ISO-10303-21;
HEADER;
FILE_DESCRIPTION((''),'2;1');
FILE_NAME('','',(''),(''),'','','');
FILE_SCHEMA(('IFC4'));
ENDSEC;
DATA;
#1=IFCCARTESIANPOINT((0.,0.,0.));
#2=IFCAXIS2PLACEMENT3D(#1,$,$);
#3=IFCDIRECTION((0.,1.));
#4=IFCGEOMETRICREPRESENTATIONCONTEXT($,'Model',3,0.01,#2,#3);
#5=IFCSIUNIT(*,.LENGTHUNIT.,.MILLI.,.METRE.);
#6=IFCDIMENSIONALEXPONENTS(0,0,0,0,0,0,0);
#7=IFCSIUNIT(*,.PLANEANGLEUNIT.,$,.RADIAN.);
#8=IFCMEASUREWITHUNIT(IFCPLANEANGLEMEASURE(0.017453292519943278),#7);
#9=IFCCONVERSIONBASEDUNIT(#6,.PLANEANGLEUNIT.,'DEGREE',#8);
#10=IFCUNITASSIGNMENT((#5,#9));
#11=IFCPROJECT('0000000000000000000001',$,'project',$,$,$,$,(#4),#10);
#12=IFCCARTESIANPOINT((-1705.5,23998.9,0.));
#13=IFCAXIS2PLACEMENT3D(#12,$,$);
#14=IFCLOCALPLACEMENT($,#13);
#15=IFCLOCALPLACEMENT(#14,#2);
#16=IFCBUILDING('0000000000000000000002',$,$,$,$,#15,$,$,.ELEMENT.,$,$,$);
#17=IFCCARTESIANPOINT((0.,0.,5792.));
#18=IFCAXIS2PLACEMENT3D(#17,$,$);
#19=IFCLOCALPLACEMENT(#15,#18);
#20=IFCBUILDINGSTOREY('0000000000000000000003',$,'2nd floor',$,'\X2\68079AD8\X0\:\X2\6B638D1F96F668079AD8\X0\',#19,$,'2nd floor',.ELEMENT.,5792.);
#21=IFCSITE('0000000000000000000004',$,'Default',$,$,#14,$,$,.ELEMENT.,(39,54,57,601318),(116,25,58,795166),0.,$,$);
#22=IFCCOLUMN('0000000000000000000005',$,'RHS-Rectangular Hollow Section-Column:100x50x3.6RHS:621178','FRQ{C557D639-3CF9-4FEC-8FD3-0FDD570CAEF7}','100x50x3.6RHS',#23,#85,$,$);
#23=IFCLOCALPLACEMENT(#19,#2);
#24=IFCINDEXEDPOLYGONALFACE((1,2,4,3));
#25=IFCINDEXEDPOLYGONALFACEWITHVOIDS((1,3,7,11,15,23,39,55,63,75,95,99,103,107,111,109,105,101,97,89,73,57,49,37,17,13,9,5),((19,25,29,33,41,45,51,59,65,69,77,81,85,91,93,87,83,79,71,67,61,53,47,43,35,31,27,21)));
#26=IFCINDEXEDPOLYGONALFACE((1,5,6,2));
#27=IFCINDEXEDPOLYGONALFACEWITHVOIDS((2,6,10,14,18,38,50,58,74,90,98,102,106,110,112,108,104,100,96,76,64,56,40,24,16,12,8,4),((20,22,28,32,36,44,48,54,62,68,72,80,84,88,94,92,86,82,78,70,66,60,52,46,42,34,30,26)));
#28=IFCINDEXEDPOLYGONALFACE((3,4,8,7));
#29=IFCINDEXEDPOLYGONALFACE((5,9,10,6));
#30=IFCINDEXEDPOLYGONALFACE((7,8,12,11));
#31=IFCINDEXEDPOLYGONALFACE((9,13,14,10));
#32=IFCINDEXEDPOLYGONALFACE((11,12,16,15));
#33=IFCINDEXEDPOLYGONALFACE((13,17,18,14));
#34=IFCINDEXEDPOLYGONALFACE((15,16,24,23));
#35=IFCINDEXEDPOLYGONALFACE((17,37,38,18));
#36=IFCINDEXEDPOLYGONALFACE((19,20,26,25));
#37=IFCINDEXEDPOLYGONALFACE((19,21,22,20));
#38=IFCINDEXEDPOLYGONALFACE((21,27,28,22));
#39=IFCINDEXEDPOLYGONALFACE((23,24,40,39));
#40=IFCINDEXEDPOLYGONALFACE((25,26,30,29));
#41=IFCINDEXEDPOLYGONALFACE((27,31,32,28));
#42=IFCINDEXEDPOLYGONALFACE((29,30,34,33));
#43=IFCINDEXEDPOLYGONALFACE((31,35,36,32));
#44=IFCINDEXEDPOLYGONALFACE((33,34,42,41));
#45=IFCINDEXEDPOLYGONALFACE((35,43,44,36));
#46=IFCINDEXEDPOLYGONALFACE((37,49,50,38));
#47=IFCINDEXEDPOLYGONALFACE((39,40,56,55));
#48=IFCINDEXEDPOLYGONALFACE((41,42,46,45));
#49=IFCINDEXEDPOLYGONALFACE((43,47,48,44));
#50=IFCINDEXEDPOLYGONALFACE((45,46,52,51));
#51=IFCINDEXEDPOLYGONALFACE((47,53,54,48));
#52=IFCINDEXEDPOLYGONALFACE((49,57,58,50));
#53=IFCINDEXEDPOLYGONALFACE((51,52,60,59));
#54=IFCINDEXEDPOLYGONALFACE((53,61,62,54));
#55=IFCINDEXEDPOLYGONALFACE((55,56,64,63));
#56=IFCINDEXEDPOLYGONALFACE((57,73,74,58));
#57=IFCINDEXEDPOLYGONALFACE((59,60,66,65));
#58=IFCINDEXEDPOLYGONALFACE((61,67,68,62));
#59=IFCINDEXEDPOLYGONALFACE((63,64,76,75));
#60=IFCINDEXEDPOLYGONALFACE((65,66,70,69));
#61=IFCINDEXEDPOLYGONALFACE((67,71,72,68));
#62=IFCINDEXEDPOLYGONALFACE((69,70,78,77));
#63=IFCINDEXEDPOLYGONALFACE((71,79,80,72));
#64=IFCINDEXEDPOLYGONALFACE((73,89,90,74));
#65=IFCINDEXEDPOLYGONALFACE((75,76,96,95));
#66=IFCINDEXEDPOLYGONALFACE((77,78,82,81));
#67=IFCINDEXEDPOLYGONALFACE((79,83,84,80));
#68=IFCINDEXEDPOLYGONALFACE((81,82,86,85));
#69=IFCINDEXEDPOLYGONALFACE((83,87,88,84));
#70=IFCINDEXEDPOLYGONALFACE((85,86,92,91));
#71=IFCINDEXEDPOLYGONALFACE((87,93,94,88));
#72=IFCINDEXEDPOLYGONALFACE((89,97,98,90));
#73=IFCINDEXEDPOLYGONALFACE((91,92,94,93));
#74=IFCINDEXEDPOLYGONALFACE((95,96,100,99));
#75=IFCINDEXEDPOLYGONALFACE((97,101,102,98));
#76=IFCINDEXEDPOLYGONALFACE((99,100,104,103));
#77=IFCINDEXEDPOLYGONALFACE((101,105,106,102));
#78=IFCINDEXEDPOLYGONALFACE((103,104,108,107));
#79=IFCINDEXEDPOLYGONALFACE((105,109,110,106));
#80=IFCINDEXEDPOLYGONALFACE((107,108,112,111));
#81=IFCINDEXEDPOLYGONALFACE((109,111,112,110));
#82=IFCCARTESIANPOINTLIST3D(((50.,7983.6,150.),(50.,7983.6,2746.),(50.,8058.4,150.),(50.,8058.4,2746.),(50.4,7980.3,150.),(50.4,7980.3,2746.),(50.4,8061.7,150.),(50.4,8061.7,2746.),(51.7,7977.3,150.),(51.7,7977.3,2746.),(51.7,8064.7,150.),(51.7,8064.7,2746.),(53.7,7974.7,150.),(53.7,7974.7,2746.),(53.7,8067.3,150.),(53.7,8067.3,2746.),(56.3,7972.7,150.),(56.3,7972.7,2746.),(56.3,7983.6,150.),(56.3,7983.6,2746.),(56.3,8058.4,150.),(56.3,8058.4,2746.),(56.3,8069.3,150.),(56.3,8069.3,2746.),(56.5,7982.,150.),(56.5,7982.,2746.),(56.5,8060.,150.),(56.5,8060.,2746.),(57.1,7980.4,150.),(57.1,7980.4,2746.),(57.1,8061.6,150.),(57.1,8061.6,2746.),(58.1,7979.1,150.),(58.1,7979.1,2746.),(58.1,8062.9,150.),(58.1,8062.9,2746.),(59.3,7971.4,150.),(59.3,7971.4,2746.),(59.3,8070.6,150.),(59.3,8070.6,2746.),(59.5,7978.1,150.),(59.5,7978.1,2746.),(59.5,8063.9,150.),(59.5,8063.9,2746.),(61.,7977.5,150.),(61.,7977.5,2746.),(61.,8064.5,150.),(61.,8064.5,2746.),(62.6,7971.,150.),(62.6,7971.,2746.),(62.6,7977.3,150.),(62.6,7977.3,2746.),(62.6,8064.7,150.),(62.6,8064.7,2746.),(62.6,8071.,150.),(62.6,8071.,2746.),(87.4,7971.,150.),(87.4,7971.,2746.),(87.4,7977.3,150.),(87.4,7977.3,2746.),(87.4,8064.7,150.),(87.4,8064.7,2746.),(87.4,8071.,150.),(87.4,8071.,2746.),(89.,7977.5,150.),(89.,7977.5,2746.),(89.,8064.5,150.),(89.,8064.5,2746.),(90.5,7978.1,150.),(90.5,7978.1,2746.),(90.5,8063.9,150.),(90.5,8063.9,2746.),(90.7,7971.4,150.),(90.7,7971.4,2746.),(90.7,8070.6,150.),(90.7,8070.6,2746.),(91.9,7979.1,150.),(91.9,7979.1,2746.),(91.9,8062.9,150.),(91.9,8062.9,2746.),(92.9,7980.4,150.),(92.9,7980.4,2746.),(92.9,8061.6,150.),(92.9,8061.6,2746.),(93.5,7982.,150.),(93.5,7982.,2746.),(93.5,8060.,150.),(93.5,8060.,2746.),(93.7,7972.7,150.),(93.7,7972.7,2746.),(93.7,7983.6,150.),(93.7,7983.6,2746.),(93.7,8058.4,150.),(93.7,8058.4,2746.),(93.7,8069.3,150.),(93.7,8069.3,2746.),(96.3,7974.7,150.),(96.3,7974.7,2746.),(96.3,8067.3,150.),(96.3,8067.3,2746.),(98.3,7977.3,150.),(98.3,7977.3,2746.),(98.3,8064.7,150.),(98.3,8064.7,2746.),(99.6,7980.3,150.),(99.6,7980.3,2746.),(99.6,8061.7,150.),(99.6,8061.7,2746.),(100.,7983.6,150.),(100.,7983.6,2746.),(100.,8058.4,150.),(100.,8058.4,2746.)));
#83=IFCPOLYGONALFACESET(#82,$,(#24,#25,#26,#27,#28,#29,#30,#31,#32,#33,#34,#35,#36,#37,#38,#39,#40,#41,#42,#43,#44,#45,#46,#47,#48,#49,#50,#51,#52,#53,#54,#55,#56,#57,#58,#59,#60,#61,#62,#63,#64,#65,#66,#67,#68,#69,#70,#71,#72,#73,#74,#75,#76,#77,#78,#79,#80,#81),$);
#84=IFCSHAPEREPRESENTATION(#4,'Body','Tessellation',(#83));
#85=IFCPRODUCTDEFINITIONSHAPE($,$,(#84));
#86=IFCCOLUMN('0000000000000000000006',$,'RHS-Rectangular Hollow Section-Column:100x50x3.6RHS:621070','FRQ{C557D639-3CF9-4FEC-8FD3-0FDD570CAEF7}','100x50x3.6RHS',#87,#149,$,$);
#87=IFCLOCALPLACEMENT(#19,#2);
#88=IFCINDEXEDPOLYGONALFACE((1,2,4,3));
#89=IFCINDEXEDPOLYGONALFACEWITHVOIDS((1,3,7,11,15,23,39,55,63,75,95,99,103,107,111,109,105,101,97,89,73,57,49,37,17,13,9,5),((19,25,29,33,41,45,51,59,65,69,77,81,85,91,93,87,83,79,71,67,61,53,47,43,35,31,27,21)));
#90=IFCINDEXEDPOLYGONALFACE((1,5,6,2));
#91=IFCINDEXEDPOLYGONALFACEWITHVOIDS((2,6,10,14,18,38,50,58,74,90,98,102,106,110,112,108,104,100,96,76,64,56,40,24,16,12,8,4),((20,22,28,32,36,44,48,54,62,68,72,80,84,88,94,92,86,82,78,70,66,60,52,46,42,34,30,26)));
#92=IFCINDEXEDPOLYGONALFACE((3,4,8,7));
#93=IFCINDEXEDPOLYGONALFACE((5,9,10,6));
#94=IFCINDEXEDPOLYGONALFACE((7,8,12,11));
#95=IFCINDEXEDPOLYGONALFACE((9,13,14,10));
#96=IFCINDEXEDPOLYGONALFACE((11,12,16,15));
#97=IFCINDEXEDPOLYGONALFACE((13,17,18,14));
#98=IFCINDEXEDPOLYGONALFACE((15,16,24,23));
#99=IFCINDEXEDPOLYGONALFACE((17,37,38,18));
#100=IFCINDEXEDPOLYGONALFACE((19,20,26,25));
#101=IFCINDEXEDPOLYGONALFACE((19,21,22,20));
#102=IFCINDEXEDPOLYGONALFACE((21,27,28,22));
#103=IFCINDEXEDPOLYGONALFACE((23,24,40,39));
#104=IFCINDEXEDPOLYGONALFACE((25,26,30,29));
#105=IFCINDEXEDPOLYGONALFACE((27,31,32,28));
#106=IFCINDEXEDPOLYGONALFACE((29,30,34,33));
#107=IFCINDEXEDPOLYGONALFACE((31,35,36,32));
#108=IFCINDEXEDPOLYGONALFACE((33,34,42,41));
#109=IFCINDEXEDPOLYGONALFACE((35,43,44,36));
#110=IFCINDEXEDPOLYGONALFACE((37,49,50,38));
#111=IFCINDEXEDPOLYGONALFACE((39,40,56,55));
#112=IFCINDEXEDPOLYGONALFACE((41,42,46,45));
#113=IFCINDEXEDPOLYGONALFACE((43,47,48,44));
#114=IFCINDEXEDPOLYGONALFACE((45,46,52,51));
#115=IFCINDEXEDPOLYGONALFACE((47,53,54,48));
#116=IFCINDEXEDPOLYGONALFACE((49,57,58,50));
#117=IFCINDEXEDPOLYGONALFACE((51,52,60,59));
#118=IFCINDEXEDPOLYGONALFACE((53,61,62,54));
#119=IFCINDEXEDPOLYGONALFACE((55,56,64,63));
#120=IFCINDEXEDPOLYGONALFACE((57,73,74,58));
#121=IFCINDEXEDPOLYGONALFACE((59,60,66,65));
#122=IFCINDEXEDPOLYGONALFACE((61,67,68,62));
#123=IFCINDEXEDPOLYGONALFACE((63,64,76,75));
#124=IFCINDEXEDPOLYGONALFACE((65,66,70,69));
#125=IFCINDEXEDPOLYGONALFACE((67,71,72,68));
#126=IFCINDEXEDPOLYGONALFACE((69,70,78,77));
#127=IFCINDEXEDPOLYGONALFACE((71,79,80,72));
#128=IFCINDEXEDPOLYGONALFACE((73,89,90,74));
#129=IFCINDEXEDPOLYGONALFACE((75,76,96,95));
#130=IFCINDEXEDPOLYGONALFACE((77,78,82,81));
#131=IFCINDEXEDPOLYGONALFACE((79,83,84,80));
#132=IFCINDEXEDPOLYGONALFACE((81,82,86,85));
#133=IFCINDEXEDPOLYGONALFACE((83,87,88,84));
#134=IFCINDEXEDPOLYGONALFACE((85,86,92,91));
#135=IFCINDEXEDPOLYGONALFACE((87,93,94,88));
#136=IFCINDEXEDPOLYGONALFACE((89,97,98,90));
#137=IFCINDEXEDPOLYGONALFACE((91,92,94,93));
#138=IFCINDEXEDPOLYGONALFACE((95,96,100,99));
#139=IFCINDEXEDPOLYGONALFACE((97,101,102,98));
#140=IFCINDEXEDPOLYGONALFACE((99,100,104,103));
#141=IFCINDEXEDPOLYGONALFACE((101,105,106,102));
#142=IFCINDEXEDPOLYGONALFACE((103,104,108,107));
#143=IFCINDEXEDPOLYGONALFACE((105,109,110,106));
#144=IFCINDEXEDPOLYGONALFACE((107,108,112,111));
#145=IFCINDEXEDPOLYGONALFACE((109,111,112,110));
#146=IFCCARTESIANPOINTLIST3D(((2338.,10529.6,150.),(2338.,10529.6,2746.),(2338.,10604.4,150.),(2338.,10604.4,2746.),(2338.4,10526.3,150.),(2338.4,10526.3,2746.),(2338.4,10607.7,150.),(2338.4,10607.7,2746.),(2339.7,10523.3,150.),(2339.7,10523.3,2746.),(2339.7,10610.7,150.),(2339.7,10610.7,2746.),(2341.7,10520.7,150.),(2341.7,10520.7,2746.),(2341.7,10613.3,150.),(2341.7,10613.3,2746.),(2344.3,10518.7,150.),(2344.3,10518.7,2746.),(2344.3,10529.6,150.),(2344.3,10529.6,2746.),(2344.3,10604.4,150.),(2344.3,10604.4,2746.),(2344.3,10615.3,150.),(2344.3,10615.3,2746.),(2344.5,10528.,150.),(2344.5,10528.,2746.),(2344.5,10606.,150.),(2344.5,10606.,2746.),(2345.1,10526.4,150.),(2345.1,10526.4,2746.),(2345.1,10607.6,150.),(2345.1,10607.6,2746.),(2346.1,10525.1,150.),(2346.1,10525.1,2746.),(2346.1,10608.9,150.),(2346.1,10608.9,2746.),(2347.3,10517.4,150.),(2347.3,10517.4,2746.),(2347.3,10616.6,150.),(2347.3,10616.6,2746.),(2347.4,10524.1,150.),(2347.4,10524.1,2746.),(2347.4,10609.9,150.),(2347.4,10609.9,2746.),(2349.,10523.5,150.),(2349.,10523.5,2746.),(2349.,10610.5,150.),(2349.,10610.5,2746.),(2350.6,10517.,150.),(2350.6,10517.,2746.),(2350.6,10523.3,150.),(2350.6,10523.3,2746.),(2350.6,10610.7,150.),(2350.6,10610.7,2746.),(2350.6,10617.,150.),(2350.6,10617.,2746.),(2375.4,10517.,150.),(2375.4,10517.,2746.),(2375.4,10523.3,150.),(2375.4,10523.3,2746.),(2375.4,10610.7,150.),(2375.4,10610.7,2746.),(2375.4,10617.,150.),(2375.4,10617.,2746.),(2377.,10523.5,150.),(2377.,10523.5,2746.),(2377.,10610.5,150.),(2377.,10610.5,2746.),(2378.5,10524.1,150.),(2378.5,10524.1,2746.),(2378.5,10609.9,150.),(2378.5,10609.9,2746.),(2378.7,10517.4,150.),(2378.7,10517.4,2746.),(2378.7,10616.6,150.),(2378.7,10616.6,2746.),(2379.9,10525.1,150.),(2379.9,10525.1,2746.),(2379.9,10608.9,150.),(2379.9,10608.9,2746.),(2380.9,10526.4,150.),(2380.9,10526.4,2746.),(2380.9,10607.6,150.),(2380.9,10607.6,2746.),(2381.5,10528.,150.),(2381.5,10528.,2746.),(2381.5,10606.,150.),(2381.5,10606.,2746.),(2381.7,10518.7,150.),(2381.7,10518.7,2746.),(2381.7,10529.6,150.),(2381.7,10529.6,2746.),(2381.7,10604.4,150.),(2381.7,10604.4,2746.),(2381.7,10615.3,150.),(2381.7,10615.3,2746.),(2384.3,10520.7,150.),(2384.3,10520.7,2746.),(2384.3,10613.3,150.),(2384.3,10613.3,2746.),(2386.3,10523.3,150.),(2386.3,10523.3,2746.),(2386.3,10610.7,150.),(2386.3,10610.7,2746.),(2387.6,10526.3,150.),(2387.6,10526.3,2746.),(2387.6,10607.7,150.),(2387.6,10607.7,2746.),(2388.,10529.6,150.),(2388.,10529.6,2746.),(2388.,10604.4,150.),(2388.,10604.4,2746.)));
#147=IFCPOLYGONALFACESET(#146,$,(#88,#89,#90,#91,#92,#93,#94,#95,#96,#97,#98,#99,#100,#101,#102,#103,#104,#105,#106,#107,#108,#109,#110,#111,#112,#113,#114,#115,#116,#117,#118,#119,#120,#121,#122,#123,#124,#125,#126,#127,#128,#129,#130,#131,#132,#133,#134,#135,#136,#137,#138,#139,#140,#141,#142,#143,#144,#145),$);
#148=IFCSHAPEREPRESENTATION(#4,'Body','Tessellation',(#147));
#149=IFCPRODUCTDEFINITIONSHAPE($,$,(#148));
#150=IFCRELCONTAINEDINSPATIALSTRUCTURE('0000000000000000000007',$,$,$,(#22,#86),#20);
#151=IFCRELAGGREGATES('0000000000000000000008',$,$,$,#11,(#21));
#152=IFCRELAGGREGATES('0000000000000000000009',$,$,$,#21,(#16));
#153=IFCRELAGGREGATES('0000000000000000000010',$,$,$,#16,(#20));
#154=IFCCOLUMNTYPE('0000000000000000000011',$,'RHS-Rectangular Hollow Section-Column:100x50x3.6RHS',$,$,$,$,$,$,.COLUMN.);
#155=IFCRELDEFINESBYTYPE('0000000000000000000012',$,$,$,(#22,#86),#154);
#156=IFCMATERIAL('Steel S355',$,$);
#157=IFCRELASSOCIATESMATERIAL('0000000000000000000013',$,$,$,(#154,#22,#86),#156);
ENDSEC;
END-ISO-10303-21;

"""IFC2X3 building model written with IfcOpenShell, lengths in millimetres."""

from ifc_helpers import new_model, entity, si_unit, converted_unit, direction, frame, origin, origin_2d, place, context, project, spatial, hollow_rectangle, extrude, clip, halfspace, material, type_object, element, save


model = new_model("IFC2X3")

# Units and contexts
model_context = context("Model", 3, precision=0.01, world=origin(), true_north=direction((0.0, 1.0)))
ifc_project = project(units=[si_unit("LENGTHUNIT", "METRE", prefix="MILLI"), converted_unit("PLANEANGLEUNIT", "DEGREE", entity("IfcPlaneAngleMeasure", 0.017453292519943278), si_unit("PLANEANGLEUNIT", "RADIAN"), dimensions=[0, 0, 0, 0, 0, 0, 0])], contexts=[model_context])

# Site, building, storey
site_placement = place(None, frame((-1705.5, 23998.9, 0.0)))
site = spatial("IfcSite", under=ifc_project, at=site_placement, Name="Default", CompositionType="ELEMENT", RefLatitude=(39, 54, 57, 601318), RefLongitude=(116, 25, 58, 795166), RefElevation=0.0)
building_placement = place(site_placement, origin())
building = spatial("IfcBuilding", under=site, at=building_placement, CompositionType="ELEMENT")
storey_placement = place(building_placement, frame((0.0, 0.0, 5792.0)))
storey = spatial("IfcBuildingStorey", under=building, at=storey_placement, Name="2nd floor", ObjectType="标高:正负零标高", LongName="2nd floor", CompositionType="ELEMENT", Elevation=5792.0)

# Columns
ifc_material_1 = material(Name="Steel S355")
column_type = type_object("IfcColumnType", Name="RHS-Rectangular Hollow Section-Column:100x50x3.6RHS", PredefinedType="COLUMN", material=ifc_material_1)
column_1_placement = place(storey_placement, frame((75.0, 8021.0, 2746.0), z_axis=(0.0, 0.0, 1.0), x_axis=(-1.0, 0.0, 0.0)))
element("IfcColumn", 1, at=column_1_placement, inside=storey, type_object=column_type, material=ifc_material_1, Name="RHS-Rectangular Hollow Section-Column:100x50x3.6RHS:621178", Description="FRQ{C557D639-3CF9-4FEC-8FD3-0FDD570CAEF7}", ObjectType="100x50x3.6RHS", context=model_context, shape_type="Clipping", body=[
    clip(extrude(hollow_rectangle(XDim=50.0, YDim=100.0, WallThickness=6.3, InnerFilletRadius=6.3, OuterFilletRadius=12.6, at=origin_2d()), origin(), (0.0, 0.0, -1.0), 2651.9), halfspace(frame((75.0, 8021.0, -2596.0), z_axis=(0.0, 0.0, 1.0), x_axis=(-1.0, 0.0, 0.0)), True)),
])
column_2_placement = place(storey_placement, frame((2363.0, 10567.0, 2746.0), z_axis=(0.0, 0.0, 1.0), x_axis=(-1.0, 0.0, 0.0)))
element("IfcColumn", 2, at=column_2_placement, inside=storey, type_object=column_type, material=ifc_material_1, Name="RHS-Rectangular Hollow Section-Column:100x50x3.6RHS:621070", Description="FRQ{C557D639-3CF9-4FEC-8FD3-0FDD570CAEF7}", ObjectType="100x50x3.6RHS", context=model_context, shape_type="Clipping", body=[
    clip(extrude(hollow_rectangle(XDim=50.0, YDim=100.0, WallThickness=6.3, InnerFilletRadius=6.3, OuterFilletRadius=12.6, at=origin_2d()), origin(), (0.0, 0.0, -1.0), 2651.9), halfspace(frame((2363.0, 10567.0, -2596.0), z_axis=(0.0, 0.0, 1.0), x_axis=(-1.0, 0.0, 0.0)), True)),
])

save(model, "model.ifc")
